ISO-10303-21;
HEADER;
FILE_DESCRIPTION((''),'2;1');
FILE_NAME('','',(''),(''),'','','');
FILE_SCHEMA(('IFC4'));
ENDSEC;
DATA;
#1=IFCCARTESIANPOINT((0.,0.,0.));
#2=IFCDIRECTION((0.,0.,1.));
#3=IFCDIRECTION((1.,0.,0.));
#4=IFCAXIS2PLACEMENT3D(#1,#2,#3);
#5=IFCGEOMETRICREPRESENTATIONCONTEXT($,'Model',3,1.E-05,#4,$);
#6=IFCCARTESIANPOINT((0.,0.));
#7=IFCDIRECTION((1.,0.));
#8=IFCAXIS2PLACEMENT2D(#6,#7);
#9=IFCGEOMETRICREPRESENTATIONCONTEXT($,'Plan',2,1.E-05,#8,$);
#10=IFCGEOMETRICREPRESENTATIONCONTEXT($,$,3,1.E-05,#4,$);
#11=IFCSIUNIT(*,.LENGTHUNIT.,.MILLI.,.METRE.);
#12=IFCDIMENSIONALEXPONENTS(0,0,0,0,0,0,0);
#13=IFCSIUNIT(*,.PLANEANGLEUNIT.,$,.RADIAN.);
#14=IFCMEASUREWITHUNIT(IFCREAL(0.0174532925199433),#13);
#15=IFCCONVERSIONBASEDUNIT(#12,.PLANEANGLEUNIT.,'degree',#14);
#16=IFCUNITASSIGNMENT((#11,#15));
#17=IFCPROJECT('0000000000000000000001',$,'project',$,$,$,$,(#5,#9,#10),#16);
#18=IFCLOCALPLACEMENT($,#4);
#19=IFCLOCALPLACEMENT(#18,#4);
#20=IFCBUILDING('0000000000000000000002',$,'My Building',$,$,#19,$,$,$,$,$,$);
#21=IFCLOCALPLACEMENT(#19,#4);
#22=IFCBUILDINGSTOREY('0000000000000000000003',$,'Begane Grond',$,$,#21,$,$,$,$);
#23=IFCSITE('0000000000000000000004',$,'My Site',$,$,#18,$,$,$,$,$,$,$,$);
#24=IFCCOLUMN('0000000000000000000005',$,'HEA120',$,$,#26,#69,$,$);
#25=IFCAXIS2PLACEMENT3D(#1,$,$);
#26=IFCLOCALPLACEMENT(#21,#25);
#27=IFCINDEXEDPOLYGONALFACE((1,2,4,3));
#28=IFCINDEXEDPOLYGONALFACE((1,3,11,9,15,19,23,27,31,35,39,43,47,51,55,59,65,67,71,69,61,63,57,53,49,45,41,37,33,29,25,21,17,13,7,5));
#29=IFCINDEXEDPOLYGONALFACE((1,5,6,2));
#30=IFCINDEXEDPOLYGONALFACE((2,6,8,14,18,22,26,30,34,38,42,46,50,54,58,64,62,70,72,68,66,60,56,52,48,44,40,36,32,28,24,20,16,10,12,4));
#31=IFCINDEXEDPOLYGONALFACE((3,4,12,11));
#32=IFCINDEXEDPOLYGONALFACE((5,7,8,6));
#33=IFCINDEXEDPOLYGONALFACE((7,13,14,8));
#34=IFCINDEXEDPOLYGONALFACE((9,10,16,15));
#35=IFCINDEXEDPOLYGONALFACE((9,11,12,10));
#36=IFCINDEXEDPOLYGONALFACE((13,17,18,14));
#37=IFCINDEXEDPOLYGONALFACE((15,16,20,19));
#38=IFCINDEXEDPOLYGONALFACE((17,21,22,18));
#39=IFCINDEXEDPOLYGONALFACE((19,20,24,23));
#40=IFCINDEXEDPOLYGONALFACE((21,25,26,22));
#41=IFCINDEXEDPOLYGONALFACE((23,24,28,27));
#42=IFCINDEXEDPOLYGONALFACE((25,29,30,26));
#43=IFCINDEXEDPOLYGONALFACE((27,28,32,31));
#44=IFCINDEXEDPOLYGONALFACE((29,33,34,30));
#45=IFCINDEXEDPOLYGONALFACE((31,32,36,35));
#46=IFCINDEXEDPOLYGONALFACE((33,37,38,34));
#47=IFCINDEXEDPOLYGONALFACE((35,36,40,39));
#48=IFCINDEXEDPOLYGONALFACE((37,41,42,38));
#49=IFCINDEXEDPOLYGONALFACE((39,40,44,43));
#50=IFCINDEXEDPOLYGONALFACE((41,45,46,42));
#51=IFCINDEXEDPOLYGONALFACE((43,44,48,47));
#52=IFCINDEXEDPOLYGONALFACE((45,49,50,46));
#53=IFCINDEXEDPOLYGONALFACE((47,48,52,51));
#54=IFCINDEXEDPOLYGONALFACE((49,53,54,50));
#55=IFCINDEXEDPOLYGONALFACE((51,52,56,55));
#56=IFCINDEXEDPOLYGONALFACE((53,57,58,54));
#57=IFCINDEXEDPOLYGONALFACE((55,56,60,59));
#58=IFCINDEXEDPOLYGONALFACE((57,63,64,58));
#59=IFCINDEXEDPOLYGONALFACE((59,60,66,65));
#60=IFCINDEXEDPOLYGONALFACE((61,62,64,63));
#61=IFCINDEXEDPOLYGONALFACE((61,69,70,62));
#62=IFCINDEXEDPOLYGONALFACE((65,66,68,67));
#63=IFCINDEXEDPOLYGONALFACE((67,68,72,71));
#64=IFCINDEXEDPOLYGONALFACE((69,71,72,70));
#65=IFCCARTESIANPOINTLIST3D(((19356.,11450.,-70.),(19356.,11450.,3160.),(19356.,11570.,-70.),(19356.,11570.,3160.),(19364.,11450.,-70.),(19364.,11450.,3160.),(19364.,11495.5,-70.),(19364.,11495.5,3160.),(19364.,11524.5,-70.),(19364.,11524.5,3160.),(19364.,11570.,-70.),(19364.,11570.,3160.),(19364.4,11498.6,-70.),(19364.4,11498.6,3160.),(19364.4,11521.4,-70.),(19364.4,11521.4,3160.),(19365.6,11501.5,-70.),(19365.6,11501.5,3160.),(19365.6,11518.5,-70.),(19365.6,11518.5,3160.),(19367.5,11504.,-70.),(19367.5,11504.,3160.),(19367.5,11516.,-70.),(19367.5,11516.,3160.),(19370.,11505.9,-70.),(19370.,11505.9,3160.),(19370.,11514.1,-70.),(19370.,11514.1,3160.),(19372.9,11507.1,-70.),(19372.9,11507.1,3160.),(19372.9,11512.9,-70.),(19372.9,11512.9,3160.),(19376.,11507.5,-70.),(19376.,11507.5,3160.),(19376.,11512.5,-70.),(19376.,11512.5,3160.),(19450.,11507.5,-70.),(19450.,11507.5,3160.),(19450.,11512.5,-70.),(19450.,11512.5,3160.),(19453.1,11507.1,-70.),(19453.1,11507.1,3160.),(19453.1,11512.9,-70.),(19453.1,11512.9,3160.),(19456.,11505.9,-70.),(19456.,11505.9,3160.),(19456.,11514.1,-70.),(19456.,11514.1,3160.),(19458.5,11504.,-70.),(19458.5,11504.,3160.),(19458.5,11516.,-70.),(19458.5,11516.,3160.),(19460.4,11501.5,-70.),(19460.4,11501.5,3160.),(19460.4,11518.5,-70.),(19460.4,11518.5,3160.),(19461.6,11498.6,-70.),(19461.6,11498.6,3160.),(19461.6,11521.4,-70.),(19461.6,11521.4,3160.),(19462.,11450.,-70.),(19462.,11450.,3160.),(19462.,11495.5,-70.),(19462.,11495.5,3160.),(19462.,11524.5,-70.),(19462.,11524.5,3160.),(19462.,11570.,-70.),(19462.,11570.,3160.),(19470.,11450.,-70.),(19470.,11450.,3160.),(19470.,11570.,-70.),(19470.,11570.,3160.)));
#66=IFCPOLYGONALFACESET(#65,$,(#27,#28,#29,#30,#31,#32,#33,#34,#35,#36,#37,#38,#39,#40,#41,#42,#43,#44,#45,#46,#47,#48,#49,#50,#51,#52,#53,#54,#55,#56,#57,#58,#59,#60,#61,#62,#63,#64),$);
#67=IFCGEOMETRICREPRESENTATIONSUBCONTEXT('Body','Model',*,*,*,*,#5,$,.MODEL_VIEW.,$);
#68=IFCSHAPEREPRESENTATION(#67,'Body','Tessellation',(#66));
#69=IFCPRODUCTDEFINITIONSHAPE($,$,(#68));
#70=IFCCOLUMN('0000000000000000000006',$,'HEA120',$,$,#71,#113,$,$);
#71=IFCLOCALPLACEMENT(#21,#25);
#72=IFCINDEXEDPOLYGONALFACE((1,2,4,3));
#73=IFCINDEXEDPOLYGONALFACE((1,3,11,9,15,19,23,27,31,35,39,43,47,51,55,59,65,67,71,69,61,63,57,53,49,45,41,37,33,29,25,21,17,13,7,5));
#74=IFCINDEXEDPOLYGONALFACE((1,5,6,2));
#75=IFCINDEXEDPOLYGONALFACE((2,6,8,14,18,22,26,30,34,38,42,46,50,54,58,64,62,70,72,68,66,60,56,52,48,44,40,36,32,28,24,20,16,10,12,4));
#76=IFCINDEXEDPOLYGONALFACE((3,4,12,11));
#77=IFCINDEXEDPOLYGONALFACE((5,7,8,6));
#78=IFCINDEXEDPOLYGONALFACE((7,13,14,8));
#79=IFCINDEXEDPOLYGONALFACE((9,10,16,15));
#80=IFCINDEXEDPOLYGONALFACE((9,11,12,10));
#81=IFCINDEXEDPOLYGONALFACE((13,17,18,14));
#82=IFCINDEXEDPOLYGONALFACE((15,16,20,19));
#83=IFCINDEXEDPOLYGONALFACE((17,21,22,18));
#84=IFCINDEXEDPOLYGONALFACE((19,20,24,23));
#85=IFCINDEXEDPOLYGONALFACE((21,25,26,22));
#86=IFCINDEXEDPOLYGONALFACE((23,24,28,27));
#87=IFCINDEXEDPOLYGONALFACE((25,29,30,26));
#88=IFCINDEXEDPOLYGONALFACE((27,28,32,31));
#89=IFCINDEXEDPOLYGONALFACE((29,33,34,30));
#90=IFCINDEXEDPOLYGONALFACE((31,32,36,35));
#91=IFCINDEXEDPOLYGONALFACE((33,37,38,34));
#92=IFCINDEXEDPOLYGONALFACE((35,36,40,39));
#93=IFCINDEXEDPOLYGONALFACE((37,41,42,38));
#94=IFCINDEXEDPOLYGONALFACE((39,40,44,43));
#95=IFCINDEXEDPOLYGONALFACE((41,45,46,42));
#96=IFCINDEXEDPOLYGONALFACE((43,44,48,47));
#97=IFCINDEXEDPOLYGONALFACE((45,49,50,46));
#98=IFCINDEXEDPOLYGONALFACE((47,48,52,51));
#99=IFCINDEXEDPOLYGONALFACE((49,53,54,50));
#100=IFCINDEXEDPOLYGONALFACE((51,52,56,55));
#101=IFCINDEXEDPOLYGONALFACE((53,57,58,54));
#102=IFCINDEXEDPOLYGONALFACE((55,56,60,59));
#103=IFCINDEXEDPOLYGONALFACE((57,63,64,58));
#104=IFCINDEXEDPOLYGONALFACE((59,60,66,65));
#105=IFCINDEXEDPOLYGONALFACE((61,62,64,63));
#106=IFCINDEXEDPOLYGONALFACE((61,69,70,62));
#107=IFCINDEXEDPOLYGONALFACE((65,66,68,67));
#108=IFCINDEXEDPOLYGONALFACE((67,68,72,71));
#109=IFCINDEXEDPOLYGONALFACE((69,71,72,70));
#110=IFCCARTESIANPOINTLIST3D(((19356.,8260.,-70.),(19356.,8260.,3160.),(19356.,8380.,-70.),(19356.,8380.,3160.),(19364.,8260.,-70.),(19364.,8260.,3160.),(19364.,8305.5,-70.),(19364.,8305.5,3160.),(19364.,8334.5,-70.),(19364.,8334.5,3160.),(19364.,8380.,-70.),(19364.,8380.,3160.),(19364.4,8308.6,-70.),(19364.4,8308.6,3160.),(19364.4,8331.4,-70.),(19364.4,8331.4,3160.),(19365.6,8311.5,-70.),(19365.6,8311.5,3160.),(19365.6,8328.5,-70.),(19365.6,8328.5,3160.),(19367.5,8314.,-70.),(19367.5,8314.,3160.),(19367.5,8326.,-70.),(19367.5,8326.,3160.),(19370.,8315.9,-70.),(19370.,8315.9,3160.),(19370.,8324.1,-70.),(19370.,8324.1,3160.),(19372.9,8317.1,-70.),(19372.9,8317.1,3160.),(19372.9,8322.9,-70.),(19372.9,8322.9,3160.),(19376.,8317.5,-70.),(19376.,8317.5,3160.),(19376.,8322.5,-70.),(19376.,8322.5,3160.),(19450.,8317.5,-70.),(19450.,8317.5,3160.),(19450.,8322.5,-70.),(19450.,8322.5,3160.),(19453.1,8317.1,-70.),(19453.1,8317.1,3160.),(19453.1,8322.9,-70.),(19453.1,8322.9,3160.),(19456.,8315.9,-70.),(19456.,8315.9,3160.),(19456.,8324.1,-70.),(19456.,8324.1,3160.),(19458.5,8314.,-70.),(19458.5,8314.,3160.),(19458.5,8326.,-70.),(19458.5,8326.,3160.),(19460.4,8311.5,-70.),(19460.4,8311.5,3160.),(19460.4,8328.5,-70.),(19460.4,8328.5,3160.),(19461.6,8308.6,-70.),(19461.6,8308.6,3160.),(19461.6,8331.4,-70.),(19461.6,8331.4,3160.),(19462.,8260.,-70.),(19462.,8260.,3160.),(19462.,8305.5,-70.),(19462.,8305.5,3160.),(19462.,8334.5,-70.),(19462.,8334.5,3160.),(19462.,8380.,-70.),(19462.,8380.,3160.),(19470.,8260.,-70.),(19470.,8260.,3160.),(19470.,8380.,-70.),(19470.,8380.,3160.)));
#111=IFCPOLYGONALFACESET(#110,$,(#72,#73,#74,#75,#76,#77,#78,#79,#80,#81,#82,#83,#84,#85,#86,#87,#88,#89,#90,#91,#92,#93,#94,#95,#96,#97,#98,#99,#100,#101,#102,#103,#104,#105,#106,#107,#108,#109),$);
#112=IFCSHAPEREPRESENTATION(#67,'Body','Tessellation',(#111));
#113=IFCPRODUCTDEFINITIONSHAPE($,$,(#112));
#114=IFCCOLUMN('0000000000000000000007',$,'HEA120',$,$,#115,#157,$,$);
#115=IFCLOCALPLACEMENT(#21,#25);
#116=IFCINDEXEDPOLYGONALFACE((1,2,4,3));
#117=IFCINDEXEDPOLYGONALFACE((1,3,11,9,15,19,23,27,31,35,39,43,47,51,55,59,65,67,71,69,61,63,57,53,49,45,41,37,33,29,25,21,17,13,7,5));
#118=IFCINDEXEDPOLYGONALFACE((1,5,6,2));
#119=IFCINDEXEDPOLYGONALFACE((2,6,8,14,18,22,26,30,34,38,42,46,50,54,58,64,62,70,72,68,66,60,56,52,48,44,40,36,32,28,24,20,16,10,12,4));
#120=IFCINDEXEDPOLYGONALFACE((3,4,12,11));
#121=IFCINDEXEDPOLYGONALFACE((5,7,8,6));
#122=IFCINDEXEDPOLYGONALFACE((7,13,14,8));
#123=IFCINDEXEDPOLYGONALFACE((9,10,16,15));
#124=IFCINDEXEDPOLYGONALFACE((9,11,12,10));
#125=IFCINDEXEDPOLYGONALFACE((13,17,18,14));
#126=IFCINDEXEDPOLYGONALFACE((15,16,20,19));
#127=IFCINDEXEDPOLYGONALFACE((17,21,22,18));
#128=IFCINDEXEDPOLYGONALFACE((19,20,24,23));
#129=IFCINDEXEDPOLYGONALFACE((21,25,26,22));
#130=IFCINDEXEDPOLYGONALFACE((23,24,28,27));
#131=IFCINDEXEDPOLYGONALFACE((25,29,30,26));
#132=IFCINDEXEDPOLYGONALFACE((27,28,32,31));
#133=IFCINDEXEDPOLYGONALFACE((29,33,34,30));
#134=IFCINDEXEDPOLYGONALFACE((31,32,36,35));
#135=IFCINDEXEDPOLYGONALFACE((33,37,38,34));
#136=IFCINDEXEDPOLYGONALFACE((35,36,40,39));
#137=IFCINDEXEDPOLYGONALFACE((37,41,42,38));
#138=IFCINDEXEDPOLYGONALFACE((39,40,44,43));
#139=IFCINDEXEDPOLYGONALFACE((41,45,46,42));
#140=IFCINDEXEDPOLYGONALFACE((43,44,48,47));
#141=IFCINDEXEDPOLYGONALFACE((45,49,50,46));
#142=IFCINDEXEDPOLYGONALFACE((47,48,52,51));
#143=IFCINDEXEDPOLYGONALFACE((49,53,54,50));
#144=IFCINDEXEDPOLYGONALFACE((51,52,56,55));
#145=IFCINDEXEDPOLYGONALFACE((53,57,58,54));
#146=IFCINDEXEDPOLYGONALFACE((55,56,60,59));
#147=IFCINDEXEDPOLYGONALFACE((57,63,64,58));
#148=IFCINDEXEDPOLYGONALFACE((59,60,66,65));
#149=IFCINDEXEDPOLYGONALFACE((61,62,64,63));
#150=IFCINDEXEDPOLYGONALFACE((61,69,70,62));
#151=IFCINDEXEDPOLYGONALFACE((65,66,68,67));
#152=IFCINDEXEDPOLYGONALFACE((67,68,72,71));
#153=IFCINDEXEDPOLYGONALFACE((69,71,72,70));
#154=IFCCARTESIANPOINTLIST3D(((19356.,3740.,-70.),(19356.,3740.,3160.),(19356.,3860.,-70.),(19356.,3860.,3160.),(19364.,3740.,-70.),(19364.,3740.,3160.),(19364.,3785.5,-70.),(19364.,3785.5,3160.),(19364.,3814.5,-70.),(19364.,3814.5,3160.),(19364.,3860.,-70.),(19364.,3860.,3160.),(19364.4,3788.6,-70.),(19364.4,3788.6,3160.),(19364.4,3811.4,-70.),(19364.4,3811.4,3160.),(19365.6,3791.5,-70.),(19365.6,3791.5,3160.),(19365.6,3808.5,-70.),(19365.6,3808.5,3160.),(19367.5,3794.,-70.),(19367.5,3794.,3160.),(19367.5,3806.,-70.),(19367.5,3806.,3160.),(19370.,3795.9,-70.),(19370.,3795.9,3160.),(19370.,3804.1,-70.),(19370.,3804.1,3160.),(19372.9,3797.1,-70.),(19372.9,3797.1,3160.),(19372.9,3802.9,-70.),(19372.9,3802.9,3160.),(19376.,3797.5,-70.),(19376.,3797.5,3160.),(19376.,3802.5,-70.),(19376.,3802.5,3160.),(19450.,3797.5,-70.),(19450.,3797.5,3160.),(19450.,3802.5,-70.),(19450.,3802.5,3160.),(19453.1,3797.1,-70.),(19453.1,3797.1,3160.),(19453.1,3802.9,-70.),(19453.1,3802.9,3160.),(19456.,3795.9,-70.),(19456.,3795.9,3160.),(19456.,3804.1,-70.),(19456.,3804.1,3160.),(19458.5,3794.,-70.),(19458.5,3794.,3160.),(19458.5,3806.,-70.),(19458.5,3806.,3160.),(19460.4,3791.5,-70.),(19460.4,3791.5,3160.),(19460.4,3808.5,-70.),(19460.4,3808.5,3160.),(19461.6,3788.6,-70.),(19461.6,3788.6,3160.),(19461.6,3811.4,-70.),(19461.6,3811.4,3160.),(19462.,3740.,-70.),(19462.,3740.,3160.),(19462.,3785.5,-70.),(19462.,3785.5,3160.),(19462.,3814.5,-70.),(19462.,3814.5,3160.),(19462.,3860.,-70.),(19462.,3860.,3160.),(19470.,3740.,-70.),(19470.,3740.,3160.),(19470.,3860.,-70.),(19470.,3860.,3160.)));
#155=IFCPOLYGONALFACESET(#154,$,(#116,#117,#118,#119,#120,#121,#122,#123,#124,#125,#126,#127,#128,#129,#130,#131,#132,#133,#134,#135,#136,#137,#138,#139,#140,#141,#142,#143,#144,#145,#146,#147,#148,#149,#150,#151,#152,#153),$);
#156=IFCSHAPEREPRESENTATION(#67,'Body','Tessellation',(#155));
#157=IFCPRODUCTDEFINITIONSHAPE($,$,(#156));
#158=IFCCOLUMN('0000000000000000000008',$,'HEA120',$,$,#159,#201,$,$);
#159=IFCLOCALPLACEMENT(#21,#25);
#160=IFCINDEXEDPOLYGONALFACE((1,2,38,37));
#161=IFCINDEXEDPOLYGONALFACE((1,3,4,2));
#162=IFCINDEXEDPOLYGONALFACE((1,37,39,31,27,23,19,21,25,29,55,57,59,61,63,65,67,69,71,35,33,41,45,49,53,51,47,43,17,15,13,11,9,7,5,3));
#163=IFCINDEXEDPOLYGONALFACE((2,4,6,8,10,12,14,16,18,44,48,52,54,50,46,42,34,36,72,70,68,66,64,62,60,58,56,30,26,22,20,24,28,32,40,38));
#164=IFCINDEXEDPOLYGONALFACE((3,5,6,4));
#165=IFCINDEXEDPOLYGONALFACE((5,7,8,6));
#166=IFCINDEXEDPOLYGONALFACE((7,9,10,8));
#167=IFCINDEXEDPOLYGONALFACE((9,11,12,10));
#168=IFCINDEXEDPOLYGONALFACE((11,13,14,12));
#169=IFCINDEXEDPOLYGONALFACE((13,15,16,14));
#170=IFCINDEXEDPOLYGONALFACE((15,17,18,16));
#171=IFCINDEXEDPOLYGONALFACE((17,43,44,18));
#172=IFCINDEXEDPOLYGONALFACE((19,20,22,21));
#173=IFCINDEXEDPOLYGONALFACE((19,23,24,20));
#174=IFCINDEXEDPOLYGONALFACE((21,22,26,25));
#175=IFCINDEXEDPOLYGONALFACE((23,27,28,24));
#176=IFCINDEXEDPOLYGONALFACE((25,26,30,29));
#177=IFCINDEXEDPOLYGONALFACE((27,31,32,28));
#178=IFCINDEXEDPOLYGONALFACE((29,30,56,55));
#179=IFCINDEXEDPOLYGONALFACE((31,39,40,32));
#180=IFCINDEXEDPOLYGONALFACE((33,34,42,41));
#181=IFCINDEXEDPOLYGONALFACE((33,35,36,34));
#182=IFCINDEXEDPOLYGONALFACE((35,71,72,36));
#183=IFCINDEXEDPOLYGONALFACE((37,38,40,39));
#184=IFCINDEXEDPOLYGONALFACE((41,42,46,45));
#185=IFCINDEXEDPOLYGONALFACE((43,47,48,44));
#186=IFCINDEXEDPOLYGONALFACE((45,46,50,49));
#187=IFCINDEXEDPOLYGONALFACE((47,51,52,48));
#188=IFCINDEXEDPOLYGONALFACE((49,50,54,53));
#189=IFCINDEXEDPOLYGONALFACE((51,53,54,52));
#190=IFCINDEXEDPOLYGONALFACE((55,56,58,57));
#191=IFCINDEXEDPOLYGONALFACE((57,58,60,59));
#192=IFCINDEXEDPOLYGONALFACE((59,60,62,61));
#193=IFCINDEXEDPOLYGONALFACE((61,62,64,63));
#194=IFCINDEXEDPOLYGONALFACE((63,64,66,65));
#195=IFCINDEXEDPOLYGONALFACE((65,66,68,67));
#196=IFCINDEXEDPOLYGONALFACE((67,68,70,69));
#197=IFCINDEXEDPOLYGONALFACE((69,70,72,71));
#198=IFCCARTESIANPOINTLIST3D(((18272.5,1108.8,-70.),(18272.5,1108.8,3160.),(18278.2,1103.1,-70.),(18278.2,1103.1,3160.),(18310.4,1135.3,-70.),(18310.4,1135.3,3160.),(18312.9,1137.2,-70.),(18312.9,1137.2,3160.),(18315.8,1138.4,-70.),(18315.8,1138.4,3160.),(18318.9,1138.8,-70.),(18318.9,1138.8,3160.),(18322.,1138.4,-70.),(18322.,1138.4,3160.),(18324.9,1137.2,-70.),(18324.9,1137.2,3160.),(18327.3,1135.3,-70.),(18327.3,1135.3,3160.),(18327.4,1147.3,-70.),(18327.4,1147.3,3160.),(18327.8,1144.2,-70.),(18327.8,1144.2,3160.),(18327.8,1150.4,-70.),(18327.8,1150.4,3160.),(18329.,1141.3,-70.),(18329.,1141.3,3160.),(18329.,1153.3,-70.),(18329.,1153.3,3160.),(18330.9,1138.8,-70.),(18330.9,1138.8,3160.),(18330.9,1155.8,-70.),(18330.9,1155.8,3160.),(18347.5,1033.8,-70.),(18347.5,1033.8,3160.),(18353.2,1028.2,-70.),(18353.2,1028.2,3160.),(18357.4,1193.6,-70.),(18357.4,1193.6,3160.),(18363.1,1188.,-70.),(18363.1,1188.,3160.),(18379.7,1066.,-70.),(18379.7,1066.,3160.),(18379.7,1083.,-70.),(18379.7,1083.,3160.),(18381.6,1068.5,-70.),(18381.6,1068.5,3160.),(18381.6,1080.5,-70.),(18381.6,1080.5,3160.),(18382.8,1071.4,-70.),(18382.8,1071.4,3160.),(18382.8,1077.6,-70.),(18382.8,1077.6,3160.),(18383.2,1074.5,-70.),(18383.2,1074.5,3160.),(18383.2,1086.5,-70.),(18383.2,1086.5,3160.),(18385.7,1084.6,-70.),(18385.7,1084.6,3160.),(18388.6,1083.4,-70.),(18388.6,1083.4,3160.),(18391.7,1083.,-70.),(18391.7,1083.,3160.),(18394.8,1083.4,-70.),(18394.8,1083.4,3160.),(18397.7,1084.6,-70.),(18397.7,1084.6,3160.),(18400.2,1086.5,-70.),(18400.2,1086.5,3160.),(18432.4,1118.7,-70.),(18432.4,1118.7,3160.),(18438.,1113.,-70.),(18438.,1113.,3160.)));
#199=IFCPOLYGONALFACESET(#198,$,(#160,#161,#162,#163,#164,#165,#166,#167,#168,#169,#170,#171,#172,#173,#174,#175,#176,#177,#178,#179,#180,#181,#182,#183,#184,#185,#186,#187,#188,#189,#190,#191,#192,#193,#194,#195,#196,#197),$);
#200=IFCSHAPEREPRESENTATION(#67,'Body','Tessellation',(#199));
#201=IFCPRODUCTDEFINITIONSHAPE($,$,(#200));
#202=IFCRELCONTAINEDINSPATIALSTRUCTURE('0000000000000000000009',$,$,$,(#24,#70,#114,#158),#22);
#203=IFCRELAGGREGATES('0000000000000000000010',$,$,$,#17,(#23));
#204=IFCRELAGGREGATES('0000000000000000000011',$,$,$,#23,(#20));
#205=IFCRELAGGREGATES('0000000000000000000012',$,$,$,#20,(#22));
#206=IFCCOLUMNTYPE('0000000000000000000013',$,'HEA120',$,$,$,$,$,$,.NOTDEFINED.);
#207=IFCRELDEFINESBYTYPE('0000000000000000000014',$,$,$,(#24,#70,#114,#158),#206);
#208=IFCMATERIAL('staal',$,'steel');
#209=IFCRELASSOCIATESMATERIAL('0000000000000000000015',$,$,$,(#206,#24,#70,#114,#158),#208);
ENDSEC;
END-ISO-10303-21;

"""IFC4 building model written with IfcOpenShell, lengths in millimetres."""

from ifc_helpers import new_model, entity, si_unit, converted_unit, frame, origin_with_axes, origin_2d_with_axis, place, context, subcontext, project, spatial, i_section, extrude, material, material_profile, profile_set, profile_usage, type_object, element, save


model = new_model("IFC4")

# Units and contexts
model_context = context("Model", 3, precision=1e-05, world=origin_with_axes())
plan_context = context("Plan", 2, precision=1e-05, world=origin_2d_with_axis())
context_of_model = context(None, 3, precision=1e-05, world=origin_with_axes())
body_context = subcontext(model_context, "Body", "Model", "MODEL_VIEW")
ifc_project = project(units=[si_unit("LENGTHUNIT", "METRE", prefix="MILLI"), converted_unit("PLANEANGLEUNIT", "degree", entity("IfcReal", 0.0174532925199433), si_unit("PLANEANGLEUNIT", "RADIAN"), dimensions=[0, 0, 0, 0, 0, 0, 0])], contexts=[model_context, plan_context, context_of_model])

# Site, building, storey
site_placement = place(None, origin_with_axes())
site = spatial("IfcSite", under=ifc_project, at=site_placement, Name="My Site")
building_placement = place(site_placement, origin_with_axes())
building = spatial("IfcBuilding", under=site, at=building_placement, Name="My Building")
storey_placement = place(building_placement, origin_with_axes())
storey = spatial("IfcBuildingStorey", under=building, at=storey_placement, Name="Begane Grond")

# Columns
ifc_material = material(Name="staal", Category="steel")
ifc_material_profile_1 = material_profile(ifc_material, i_section(OverallWidth=120.0, OverallDepth=114.0, WebThickness=5.0, FlangeThickness=8.0, FilletRadius=12.0))
ifc_profile_set_1 = profile_set([ifc_material_profile_1], Name="HEA120")
column_type_1 = type_object("IfcColumnType", Name="HEA120", PredefinedType="NOTDEFINED", material=ifc_profile_set_1)
ifc_profile_usage_1 = profile_usage(ifc_profile_set_1)
column_1_placement = place(storey_placement, frame((19413.0, 11510.0, -70.0), z_axis=(0.0, 0.0, 1.0), x_axis=(0.0, 1.0, 0.0)))
element("IfcColumn", 1, at=column_1_placement, inside=storey, type_object=column_type_1, material=ifc_profile_usage_1, Name="HEA120", context=body_context, shape_type="SweptSolid", body=[
    extrude(i_section(OverallWidth=120.0, OverallDepth=114.0, WebThickness=5.0, FlangeThickness=8.0, FilletRadius=12.0), origin_with_axes(), (0.0, 0.0, 1.0), 3230.0),
])
ifc_profile_usage_2 = profile_usage(ifc_profile_set_1)
column_2_placement = place(storey_placement, frame((19413.0, 8320.0, -70.0), z_axis=(0.0, 0.0, 1.0), x_axis=(0.0, 1.0, 0.0)))
element("IfcColumn", 2, at=column_2_placement, inside=storey, type_object=column_type_1, material=ifc_profile_usage_2, Name="HEA120", context=body_context, shape_type="SweptSolid", body=[
    extrude(i_section(OverallWidth=120.0, OverallDepth=114.0, WebThickness=5.0, FlangeThickness=8.0, FilletRadius=12.0), origin_with_axes(), (0.0, 0.0, 1.0), 3230.0),
])
ifc_profile_usage_3 = profile_usage(ifc_profile_set_1)
column_3_placement = place(storey_placement, frame((19413.0, 3800.0, -70.0), z_axis=(0.0, 0.0, 1.0), x_axis=(0.0, 1.0, 0.0)))
element("IfcColumn", 3, at=column_3_placement, inside=storey, type_object=column_type_1, material=ifc_profile_usage_3, Name="HEA120", context=body_context, shape_type="SweptSolid", body=[
    extrude(i_section(OverallWidth=120.0, OverallDepth=114.0, WebThickness=5.0, FlangeThickness=8.0, FilletRadius=12.0), origin_with_axes(), (0.0, 0.0, 1.0), 3230.0),
])
ifc_profile_usage_4 = profile_usage(ifc_profile_set_1)
column_4_placement = place(storey_placement, frame((18355.3, 1110.9, -70.0), z_axis=(0.0, 0.0, 1.0), x_axis=(0.707107, 0.707107, 0.0)))
element("IfcColumn", 4, at=column_4_placement, inside=storey, type_object=column_type_1, material=ifc_profile_usage_4, Name="HEA120", context=body_context, shape_type="SweptSolid", body=[
    extrude(i_section(OverallWidth=120.0, OverallDepth=114.0, WebThickness=5.0, FlangeThickness=8.0, FilletRadius=12.0), origin_with_axes(), (0.0, 0.0, 1.0), 3230.0),
])

save(model, "model.ifc")
